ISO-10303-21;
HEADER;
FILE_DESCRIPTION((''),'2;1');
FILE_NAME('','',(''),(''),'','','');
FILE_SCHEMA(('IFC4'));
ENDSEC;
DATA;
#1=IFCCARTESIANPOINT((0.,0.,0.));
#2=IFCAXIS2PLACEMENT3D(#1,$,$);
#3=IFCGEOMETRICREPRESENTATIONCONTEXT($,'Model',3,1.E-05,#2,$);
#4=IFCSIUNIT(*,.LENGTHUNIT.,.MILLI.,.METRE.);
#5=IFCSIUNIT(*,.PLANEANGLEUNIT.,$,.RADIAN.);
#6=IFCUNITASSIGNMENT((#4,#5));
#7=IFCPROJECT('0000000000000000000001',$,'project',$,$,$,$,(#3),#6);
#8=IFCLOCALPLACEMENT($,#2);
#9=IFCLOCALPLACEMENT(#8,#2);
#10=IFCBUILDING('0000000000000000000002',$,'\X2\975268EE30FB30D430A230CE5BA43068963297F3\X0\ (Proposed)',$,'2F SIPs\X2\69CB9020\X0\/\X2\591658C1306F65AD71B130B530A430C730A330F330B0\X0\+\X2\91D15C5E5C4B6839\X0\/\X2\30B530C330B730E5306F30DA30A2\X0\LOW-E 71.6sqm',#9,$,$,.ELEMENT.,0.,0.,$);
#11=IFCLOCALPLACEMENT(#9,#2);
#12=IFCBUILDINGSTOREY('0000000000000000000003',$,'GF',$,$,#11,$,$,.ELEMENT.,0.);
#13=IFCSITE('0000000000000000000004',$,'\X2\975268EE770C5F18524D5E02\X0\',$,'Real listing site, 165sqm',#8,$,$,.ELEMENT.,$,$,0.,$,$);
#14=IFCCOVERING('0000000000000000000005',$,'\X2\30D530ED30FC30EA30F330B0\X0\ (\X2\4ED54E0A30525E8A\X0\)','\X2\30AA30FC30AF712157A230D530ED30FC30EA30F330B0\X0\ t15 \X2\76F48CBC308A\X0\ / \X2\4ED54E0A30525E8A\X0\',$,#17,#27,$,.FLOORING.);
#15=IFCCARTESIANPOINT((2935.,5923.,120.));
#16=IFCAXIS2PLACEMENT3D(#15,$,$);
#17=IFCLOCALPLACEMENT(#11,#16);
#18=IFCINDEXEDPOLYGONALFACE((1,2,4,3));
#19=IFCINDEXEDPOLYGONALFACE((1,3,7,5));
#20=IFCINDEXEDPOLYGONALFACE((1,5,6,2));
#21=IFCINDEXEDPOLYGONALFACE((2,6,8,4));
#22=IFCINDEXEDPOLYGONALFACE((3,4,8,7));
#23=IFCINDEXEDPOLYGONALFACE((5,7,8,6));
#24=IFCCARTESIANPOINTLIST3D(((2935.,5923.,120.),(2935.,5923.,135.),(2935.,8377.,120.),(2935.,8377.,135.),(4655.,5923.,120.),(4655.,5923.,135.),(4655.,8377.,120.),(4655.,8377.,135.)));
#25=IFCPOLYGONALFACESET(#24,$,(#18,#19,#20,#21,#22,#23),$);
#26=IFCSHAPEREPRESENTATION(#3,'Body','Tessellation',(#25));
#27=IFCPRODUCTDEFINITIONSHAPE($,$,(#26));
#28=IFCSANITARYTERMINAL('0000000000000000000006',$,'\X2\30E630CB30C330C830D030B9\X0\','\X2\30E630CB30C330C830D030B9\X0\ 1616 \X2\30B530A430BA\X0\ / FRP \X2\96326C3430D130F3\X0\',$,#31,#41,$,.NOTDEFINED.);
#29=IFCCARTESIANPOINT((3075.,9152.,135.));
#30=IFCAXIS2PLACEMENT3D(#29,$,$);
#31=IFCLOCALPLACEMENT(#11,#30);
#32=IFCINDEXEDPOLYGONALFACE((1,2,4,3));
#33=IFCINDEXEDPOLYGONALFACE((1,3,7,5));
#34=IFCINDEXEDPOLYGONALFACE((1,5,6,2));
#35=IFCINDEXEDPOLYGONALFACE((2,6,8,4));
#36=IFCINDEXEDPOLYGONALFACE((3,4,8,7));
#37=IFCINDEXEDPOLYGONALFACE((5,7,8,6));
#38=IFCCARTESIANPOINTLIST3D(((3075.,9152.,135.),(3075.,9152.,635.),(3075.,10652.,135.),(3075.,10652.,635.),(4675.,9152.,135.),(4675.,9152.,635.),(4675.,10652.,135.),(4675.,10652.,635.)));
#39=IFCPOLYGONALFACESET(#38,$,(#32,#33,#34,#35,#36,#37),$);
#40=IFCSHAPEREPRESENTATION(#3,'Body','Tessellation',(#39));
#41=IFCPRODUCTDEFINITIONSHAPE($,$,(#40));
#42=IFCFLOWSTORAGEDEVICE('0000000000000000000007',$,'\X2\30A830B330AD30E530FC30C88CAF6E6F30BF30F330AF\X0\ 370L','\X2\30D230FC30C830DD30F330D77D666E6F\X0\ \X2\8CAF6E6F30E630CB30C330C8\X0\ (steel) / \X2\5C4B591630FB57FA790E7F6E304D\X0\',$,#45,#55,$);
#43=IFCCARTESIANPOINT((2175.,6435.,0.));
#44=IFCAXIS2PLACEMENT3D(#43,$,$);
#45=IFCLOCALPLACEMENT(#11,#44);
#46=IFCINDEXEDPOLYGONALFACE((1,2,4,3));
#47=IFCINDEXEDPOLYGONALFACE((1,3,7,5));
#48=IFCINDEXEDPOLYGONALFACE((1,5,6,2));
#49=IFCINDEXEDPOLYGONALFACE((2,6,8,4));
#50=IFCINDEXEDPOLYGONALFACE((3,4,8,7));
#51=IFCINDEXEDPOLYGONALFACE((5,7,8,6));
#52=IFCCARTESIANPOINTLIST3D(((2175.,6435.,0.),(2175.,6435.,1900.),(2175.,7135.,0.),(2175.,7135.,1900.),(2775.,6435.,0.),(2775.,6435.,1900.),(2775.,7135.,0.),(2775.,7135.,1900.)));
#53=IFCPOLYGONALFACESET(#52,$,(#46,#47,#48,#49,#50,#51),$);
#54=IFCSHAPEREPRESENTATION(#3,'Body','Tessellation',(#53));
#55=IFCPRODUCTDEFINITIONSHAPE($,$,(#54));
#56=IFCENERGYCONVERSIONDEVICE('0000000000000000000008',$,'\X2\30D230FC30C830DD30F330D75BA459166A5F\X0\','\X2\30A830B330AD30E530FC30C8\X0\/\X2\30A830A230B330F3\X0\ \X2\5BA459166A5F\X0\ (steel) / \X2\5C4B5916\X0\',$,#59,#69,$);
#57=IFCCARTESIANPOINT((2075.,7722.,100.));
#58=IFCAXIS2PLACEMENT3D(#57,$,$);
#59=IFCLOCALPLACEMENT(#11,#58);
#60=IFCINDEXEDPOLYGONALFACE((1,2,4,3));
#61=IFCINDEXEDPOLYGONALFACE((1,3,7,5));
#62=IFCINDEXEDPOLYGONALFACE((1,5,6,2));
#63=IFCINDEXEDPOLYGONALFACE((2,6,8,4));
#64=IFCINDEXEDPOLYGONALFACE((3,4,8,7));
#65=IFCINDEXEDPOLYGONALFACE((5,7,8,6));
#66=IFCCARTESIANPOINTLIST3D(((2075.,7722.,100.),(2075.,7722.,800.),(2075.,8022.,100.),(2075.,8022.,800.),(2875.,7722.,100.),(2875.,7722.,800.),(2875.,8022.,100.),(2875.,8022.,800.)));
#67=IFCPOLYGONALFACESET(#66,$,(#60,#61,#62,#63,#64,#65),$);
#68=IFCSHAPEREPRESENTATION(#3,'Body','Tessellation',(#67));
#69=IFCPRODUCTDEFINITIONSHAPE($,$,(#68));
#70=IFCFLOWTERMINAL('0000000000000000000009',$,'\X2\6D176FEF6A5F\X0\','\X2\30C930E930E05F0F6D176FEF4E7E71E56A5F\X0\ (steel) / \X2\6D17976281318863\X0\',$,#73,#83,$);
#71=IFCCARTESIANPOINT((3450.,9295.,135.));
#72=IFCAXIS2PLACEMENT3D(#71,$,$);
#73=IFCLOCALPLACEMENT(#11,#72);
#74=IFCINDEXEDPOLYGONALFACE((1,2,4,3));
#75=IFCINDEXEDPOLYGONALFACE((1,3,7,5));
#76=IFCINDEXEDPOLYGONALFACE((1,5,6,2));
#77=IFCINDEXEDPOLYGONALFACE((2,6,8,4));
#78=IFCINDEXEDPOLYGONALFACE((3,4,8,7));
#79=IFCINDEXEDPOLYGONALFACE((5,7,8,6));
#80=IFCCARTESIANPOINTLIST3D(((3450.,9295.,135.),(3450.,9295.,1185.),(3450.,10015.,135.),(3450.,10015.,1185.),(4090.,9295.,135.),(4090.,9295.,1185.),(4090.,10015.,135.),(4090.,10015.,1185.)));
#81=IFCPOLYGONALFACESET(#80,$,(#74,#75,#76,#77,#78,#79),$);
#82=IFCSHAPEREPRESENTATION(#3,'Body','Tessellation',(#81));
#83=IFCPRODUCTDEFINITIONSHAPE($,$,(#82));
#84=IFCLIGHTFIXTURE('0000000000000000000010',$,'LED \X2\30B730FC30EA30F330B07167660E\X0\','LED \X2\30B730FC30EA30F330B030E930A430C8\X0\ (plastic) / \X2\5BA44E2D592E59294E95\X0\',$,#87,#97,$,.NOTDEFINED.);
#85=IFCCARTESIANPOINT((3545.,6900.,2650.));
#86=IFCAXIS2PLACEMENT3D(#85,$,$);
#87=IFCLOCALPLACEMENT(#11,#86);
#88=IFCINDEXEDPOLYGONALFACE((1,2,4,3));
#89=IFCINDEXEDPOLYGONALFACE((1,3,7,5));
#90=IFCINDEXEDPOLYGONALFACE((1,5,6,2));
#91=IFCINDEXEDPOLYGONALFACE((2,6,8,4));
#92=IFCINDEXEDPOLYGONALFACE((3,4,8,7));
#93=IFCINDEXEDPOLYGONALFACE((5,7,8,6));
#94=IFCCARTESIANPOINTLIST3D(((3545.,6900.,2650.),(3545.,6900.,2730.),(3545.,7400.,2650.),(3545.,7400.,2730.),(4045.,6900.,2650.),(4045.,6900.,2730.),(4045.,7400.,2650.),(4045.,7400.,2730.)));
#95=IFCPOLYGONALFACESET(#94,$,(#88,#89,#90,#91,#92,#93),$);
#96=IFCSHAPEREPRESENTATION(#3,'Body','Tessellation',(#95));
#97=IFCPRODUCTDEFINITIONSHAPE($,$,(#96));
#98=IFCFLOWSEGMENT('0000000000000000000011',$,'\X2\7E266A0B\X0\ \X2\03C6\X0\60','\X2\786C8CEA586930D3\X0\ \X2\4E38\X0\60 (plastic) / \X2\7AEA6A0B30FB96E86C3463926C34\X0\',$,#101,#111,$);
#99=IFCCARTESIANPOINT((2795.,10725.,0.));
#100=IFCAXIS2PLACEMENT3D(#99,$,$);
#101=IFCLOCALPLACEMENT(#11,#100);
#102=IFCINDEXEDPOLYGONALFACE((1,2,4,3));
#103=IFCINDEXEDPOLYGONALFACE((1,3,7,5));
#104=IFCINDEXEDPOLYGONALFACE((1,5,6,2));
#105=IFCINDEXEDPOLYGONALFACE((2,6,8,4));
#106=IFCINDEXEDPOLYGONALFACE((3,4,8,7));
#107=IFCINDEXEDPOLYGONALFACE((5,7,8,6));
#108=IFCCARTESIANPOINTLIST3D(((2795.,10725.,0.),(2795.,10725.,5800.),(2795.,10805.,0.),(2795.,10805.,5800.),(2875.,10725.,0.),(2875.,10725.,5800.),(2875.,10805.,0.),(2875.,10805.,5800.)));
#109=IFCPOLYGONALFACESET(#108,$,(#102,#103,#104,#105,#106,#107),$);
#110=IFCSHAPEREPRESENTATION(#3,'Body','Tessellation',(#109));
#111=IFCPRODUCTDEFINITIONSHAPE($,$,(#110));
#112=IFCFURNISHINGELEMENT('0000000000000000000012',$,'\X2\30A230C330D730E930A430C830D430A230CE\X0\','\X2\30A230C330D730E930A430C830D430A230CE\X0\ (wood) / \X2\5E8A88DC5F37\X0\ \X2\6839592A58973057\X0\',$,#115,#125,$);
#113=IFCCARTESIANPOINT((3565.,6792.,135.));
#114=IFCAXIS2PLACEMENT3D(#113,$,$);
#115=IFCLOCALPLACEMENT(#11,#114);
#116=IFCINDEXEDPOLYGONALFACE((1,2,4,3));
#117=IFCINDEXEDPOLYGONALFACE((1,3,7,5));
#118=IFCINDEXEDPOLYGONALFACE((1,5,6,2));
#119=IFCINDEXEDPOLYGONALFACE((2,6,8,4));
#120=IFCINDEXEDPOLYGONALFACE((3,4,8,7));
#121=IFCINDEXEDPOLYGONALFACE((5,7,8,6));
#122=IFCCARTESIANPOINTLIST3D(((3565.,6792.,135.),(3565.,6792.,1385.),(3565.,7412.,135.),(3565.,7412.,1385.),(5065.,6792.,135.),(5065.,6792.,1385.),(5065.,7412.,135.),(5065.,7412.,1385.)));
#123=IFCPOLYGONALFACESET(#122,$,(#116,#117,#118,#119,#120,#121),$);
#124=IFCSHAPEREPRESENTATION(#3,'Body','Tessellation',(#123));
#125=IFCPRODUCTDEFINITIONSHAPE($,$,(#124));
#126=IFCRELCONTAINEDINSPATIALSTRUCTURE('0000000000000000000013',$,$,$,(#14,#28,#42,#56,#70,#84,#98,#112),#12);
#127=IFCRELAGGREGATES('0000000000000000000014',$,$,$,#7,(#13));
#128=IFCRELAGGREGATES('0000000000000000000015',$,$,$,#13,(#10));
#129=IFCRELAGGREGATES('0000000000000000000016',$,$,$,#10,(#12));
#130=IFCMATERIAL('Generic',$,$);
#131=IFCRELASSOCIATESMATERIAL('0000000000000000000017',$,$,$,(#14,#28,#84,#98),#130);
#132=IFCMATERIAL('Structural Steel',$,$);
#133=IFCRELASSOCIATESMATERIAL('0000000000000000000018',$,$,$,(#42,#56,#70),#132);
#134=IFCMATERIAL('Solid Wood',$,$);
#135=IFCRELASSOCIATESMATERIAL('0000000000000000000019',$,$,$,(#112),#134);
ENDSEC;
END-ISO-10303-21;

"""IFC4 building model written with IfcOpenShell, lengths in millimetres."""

from ifc_helpers import new_model, si_unit, frame, frame_2d, origin, place, context, project, spatial, rectangle, extrude, material, element, save


model = new_model("IFC4")

# Units and contexts
model_context = context("Model", 3, precision=1e-05, world=origin())
ifc_project = project(units=[si_unit("LENGTHUNIT", "METRE", prefix="MILLI"), si_unit("PLANEANGLEUNIT", "RADIAN")], contexts=[model_context])

# Site, building, storey
site_placement = place(None, origin())
site = spatial("IfcSite", under=ifc_project, at=site_placement, Name="青森県弘前市", ObjectType="Real listing site, 165sqm", CompositionType="ELEMENT", RefElevation=0.0)
building_placement = place(site_placement, origin())
building = spatial("IfcBuilding", under=site, at=building_placement, Name="青森・ピアノ室と防音 (Proposed)", ObjectType="2F SIPs構造/外壁は断熱サイディング+金属屋根/サッシュはペアLOW-E 71.6sqm", CompositionType="ELEMENT", ElevationOfRefHeight=0.0, ElevationOfTerrain=0.0)
storey_placement = place(building_placement, origin())
storey = spatial("IfcBuildingStorey", under=building, at=storey_placement, Name="GF", CompositionType="ELEMENT", Elevation=0.0)

# Shared definitions
ifc_material_1 = material(Name="Solid Wood")

# Covering
ifc_material_2 = material(Name="Generic")
covering_1_placement = place(storey_placement, frame((2935.0, 5923.0, 120.0)))
element("IfcCovering", 1, at=covering_1_placement, inside=storey, material=ifc_material_2, Name="フローリング (仕上げ床)", Description="オーク無垢フローリング t15 直貼り / 仕上げ床", PredefinedType="FLOORING", context=model_context, shape_type="SweptSolid", body=[
    extrude(rectangle(XDim=1720.0, YDim=2454.0, at=frame_2d((860.0, 1227.0))), frame((2935.0, 5923.0, 120.0)), (0.0, 0.0, 1.0), 15.0),
])

# Sanitary terminal
sanitary_terminal_placement = place(storey_placement, frame((3075.0, 9152.0, 135.0)))
element("IfcSanitaryTerminal", 2, at=sanitary_terminal_placement, inside=storey, material=ifc_material_2, Name="ユニットバス", Description="ユニットバス 1616 サイズ / FRP 防水パン", PredefinedType="NOTDEFINED", context=model_context, shape_type="SweptSolid", body=[
    extrude(rectangle(XDim=1600.0, YDim=1500.0, at=frame_2d((800.0, 750.0))), frame((3075.0, 9152.0, 135.0)), (0.0, 0.0, 1.0), 500.0),
])

# Flow storage device
ifc_material_3 = material(Name="Structural Steel")
flow_storage_device_placement = place(storey_placement, frame((2175.0, 6435.0, 0.0)))
element("IfcFlowStorageDevice", 3, at=flow_storage_device_placement, inside=storey, material=ifc_material_3, Name="エコキュート貯湯タンク 370L", Description="ヒートポンプ給湯 貯湯ユニット (steel) / 屋外・基礎置き", context=model_context, shape_type="SweptSolid", body=[
    extrude(rectangle(XDim=600.0, YDim=700.0, at=frame_2d((300.0, 350.0))), frame((2175.0, 6435.0, 0.0)), (0.0, 0.0, 1.0), 1900.0),
])

# Energy conversion device
energy_conversion_device_placement = place(storey_placement, frame((2075.0, 7722.0, 100.0)))
element("IfcEnergyConversionDevice", 4, at=energy_conversion_device_placement, inside=storey, material=ifc_material_3, Name="ヒートポンプ室外機", Description="エコキュート/エアコン 室外機 (steel) / 屋外", context=model_context, shape_type="SweptSolid", body=[
    extrude(rectangle(XDim=800.0, YDim=300.0, at=frame_2d((400.0, 150.0))), frame((2075.0, 7722.0, 100.0)), (0.0, 0.0, 1.0), 700.0),
])

# Flow terminal
flow_terminal_placement = place(storey_placement, frame((3450.0, 9295.0, 135.0)))
element("IfcFlowTerminal", 5, at=flow_terminal_placement, inside=storey, material=ifc_material_3, Name="洗濯機", Description="ドラム式洗濯乾燥機 (steel) / 洗面脱衣", context=model_context, shape_type="SweptSolid", body=[
    extrude(rectangle(XDim=640.0, YDim=720.0, at=frame_2d((320.0, 360.0))), frame((3450.0, 9295.0, 135.0)), (0.0, 0.0, 1.0), 1050.0),
])

# Light fixture
light_fixture_placement = place(storey_placement, frame((3545.0, 6900.0, 2650.0)))
element("IfcLightFixture", 6, at=light_fixture_placement, inside=storey, material=ifc_material_2, Name="LED シーリング照明", Description="LED シーリングライト (plastic) / 室中央天井", PredefinedType="NOTDEFINED", context=model_context, shape_type="SweptSolid", body=[
    extrude(rectangle(XDim=500.0, YDim=500.0, at=frame_2d((250.0, 250.0))), frame((3545.0, 6900.0, 2650.0)), (0.0, 0.0, 1.0), 80.0),
])

# Flow segment
flow_segment_placement = place(storey_placement, frame((2795.0, 10725.0, 0.0)))
element("IfcFlowSegment", 7, at=flow_segment_placement, inside=storey, material=ifc_material_2, Name="縦樋 φ60", Description="硬質塩ビ 丸60 (plastic) / 竪樋・雨水排水", context=model_context, shape_type="SweptSolid", body=[
    extrude(rectangle(XDim=80.0, YDim=80.0, at=frame_2d((40.0, 40.0))), frame((2795.0, 10725.0, 0.0)), (0.0, 0.0, 1.0), 5800.0),
])

# Furnishing element
furnishing_placement = place(storey_placement, frame((3565.0, 6792.0, 135.0)))
element("IfcFurnishingElement", 8, at=furnishing_placement, inside=storey, material=ifc_material_1, Name="アップライトピアノ", Description="アップライトピアノ (wood) / 床補強 根太増し", context=model_context, shape_type="SweptSolid", body=[
    extrude(rectangle(XDim=1500.0, YDim=620.0, at=frame_2d((750.0, 310.0))), frame((3565.0, 6792.0, 135.0)), (0.0, 0.0, 1.0), 1250.0),
])

save(model, "model.ifc")
